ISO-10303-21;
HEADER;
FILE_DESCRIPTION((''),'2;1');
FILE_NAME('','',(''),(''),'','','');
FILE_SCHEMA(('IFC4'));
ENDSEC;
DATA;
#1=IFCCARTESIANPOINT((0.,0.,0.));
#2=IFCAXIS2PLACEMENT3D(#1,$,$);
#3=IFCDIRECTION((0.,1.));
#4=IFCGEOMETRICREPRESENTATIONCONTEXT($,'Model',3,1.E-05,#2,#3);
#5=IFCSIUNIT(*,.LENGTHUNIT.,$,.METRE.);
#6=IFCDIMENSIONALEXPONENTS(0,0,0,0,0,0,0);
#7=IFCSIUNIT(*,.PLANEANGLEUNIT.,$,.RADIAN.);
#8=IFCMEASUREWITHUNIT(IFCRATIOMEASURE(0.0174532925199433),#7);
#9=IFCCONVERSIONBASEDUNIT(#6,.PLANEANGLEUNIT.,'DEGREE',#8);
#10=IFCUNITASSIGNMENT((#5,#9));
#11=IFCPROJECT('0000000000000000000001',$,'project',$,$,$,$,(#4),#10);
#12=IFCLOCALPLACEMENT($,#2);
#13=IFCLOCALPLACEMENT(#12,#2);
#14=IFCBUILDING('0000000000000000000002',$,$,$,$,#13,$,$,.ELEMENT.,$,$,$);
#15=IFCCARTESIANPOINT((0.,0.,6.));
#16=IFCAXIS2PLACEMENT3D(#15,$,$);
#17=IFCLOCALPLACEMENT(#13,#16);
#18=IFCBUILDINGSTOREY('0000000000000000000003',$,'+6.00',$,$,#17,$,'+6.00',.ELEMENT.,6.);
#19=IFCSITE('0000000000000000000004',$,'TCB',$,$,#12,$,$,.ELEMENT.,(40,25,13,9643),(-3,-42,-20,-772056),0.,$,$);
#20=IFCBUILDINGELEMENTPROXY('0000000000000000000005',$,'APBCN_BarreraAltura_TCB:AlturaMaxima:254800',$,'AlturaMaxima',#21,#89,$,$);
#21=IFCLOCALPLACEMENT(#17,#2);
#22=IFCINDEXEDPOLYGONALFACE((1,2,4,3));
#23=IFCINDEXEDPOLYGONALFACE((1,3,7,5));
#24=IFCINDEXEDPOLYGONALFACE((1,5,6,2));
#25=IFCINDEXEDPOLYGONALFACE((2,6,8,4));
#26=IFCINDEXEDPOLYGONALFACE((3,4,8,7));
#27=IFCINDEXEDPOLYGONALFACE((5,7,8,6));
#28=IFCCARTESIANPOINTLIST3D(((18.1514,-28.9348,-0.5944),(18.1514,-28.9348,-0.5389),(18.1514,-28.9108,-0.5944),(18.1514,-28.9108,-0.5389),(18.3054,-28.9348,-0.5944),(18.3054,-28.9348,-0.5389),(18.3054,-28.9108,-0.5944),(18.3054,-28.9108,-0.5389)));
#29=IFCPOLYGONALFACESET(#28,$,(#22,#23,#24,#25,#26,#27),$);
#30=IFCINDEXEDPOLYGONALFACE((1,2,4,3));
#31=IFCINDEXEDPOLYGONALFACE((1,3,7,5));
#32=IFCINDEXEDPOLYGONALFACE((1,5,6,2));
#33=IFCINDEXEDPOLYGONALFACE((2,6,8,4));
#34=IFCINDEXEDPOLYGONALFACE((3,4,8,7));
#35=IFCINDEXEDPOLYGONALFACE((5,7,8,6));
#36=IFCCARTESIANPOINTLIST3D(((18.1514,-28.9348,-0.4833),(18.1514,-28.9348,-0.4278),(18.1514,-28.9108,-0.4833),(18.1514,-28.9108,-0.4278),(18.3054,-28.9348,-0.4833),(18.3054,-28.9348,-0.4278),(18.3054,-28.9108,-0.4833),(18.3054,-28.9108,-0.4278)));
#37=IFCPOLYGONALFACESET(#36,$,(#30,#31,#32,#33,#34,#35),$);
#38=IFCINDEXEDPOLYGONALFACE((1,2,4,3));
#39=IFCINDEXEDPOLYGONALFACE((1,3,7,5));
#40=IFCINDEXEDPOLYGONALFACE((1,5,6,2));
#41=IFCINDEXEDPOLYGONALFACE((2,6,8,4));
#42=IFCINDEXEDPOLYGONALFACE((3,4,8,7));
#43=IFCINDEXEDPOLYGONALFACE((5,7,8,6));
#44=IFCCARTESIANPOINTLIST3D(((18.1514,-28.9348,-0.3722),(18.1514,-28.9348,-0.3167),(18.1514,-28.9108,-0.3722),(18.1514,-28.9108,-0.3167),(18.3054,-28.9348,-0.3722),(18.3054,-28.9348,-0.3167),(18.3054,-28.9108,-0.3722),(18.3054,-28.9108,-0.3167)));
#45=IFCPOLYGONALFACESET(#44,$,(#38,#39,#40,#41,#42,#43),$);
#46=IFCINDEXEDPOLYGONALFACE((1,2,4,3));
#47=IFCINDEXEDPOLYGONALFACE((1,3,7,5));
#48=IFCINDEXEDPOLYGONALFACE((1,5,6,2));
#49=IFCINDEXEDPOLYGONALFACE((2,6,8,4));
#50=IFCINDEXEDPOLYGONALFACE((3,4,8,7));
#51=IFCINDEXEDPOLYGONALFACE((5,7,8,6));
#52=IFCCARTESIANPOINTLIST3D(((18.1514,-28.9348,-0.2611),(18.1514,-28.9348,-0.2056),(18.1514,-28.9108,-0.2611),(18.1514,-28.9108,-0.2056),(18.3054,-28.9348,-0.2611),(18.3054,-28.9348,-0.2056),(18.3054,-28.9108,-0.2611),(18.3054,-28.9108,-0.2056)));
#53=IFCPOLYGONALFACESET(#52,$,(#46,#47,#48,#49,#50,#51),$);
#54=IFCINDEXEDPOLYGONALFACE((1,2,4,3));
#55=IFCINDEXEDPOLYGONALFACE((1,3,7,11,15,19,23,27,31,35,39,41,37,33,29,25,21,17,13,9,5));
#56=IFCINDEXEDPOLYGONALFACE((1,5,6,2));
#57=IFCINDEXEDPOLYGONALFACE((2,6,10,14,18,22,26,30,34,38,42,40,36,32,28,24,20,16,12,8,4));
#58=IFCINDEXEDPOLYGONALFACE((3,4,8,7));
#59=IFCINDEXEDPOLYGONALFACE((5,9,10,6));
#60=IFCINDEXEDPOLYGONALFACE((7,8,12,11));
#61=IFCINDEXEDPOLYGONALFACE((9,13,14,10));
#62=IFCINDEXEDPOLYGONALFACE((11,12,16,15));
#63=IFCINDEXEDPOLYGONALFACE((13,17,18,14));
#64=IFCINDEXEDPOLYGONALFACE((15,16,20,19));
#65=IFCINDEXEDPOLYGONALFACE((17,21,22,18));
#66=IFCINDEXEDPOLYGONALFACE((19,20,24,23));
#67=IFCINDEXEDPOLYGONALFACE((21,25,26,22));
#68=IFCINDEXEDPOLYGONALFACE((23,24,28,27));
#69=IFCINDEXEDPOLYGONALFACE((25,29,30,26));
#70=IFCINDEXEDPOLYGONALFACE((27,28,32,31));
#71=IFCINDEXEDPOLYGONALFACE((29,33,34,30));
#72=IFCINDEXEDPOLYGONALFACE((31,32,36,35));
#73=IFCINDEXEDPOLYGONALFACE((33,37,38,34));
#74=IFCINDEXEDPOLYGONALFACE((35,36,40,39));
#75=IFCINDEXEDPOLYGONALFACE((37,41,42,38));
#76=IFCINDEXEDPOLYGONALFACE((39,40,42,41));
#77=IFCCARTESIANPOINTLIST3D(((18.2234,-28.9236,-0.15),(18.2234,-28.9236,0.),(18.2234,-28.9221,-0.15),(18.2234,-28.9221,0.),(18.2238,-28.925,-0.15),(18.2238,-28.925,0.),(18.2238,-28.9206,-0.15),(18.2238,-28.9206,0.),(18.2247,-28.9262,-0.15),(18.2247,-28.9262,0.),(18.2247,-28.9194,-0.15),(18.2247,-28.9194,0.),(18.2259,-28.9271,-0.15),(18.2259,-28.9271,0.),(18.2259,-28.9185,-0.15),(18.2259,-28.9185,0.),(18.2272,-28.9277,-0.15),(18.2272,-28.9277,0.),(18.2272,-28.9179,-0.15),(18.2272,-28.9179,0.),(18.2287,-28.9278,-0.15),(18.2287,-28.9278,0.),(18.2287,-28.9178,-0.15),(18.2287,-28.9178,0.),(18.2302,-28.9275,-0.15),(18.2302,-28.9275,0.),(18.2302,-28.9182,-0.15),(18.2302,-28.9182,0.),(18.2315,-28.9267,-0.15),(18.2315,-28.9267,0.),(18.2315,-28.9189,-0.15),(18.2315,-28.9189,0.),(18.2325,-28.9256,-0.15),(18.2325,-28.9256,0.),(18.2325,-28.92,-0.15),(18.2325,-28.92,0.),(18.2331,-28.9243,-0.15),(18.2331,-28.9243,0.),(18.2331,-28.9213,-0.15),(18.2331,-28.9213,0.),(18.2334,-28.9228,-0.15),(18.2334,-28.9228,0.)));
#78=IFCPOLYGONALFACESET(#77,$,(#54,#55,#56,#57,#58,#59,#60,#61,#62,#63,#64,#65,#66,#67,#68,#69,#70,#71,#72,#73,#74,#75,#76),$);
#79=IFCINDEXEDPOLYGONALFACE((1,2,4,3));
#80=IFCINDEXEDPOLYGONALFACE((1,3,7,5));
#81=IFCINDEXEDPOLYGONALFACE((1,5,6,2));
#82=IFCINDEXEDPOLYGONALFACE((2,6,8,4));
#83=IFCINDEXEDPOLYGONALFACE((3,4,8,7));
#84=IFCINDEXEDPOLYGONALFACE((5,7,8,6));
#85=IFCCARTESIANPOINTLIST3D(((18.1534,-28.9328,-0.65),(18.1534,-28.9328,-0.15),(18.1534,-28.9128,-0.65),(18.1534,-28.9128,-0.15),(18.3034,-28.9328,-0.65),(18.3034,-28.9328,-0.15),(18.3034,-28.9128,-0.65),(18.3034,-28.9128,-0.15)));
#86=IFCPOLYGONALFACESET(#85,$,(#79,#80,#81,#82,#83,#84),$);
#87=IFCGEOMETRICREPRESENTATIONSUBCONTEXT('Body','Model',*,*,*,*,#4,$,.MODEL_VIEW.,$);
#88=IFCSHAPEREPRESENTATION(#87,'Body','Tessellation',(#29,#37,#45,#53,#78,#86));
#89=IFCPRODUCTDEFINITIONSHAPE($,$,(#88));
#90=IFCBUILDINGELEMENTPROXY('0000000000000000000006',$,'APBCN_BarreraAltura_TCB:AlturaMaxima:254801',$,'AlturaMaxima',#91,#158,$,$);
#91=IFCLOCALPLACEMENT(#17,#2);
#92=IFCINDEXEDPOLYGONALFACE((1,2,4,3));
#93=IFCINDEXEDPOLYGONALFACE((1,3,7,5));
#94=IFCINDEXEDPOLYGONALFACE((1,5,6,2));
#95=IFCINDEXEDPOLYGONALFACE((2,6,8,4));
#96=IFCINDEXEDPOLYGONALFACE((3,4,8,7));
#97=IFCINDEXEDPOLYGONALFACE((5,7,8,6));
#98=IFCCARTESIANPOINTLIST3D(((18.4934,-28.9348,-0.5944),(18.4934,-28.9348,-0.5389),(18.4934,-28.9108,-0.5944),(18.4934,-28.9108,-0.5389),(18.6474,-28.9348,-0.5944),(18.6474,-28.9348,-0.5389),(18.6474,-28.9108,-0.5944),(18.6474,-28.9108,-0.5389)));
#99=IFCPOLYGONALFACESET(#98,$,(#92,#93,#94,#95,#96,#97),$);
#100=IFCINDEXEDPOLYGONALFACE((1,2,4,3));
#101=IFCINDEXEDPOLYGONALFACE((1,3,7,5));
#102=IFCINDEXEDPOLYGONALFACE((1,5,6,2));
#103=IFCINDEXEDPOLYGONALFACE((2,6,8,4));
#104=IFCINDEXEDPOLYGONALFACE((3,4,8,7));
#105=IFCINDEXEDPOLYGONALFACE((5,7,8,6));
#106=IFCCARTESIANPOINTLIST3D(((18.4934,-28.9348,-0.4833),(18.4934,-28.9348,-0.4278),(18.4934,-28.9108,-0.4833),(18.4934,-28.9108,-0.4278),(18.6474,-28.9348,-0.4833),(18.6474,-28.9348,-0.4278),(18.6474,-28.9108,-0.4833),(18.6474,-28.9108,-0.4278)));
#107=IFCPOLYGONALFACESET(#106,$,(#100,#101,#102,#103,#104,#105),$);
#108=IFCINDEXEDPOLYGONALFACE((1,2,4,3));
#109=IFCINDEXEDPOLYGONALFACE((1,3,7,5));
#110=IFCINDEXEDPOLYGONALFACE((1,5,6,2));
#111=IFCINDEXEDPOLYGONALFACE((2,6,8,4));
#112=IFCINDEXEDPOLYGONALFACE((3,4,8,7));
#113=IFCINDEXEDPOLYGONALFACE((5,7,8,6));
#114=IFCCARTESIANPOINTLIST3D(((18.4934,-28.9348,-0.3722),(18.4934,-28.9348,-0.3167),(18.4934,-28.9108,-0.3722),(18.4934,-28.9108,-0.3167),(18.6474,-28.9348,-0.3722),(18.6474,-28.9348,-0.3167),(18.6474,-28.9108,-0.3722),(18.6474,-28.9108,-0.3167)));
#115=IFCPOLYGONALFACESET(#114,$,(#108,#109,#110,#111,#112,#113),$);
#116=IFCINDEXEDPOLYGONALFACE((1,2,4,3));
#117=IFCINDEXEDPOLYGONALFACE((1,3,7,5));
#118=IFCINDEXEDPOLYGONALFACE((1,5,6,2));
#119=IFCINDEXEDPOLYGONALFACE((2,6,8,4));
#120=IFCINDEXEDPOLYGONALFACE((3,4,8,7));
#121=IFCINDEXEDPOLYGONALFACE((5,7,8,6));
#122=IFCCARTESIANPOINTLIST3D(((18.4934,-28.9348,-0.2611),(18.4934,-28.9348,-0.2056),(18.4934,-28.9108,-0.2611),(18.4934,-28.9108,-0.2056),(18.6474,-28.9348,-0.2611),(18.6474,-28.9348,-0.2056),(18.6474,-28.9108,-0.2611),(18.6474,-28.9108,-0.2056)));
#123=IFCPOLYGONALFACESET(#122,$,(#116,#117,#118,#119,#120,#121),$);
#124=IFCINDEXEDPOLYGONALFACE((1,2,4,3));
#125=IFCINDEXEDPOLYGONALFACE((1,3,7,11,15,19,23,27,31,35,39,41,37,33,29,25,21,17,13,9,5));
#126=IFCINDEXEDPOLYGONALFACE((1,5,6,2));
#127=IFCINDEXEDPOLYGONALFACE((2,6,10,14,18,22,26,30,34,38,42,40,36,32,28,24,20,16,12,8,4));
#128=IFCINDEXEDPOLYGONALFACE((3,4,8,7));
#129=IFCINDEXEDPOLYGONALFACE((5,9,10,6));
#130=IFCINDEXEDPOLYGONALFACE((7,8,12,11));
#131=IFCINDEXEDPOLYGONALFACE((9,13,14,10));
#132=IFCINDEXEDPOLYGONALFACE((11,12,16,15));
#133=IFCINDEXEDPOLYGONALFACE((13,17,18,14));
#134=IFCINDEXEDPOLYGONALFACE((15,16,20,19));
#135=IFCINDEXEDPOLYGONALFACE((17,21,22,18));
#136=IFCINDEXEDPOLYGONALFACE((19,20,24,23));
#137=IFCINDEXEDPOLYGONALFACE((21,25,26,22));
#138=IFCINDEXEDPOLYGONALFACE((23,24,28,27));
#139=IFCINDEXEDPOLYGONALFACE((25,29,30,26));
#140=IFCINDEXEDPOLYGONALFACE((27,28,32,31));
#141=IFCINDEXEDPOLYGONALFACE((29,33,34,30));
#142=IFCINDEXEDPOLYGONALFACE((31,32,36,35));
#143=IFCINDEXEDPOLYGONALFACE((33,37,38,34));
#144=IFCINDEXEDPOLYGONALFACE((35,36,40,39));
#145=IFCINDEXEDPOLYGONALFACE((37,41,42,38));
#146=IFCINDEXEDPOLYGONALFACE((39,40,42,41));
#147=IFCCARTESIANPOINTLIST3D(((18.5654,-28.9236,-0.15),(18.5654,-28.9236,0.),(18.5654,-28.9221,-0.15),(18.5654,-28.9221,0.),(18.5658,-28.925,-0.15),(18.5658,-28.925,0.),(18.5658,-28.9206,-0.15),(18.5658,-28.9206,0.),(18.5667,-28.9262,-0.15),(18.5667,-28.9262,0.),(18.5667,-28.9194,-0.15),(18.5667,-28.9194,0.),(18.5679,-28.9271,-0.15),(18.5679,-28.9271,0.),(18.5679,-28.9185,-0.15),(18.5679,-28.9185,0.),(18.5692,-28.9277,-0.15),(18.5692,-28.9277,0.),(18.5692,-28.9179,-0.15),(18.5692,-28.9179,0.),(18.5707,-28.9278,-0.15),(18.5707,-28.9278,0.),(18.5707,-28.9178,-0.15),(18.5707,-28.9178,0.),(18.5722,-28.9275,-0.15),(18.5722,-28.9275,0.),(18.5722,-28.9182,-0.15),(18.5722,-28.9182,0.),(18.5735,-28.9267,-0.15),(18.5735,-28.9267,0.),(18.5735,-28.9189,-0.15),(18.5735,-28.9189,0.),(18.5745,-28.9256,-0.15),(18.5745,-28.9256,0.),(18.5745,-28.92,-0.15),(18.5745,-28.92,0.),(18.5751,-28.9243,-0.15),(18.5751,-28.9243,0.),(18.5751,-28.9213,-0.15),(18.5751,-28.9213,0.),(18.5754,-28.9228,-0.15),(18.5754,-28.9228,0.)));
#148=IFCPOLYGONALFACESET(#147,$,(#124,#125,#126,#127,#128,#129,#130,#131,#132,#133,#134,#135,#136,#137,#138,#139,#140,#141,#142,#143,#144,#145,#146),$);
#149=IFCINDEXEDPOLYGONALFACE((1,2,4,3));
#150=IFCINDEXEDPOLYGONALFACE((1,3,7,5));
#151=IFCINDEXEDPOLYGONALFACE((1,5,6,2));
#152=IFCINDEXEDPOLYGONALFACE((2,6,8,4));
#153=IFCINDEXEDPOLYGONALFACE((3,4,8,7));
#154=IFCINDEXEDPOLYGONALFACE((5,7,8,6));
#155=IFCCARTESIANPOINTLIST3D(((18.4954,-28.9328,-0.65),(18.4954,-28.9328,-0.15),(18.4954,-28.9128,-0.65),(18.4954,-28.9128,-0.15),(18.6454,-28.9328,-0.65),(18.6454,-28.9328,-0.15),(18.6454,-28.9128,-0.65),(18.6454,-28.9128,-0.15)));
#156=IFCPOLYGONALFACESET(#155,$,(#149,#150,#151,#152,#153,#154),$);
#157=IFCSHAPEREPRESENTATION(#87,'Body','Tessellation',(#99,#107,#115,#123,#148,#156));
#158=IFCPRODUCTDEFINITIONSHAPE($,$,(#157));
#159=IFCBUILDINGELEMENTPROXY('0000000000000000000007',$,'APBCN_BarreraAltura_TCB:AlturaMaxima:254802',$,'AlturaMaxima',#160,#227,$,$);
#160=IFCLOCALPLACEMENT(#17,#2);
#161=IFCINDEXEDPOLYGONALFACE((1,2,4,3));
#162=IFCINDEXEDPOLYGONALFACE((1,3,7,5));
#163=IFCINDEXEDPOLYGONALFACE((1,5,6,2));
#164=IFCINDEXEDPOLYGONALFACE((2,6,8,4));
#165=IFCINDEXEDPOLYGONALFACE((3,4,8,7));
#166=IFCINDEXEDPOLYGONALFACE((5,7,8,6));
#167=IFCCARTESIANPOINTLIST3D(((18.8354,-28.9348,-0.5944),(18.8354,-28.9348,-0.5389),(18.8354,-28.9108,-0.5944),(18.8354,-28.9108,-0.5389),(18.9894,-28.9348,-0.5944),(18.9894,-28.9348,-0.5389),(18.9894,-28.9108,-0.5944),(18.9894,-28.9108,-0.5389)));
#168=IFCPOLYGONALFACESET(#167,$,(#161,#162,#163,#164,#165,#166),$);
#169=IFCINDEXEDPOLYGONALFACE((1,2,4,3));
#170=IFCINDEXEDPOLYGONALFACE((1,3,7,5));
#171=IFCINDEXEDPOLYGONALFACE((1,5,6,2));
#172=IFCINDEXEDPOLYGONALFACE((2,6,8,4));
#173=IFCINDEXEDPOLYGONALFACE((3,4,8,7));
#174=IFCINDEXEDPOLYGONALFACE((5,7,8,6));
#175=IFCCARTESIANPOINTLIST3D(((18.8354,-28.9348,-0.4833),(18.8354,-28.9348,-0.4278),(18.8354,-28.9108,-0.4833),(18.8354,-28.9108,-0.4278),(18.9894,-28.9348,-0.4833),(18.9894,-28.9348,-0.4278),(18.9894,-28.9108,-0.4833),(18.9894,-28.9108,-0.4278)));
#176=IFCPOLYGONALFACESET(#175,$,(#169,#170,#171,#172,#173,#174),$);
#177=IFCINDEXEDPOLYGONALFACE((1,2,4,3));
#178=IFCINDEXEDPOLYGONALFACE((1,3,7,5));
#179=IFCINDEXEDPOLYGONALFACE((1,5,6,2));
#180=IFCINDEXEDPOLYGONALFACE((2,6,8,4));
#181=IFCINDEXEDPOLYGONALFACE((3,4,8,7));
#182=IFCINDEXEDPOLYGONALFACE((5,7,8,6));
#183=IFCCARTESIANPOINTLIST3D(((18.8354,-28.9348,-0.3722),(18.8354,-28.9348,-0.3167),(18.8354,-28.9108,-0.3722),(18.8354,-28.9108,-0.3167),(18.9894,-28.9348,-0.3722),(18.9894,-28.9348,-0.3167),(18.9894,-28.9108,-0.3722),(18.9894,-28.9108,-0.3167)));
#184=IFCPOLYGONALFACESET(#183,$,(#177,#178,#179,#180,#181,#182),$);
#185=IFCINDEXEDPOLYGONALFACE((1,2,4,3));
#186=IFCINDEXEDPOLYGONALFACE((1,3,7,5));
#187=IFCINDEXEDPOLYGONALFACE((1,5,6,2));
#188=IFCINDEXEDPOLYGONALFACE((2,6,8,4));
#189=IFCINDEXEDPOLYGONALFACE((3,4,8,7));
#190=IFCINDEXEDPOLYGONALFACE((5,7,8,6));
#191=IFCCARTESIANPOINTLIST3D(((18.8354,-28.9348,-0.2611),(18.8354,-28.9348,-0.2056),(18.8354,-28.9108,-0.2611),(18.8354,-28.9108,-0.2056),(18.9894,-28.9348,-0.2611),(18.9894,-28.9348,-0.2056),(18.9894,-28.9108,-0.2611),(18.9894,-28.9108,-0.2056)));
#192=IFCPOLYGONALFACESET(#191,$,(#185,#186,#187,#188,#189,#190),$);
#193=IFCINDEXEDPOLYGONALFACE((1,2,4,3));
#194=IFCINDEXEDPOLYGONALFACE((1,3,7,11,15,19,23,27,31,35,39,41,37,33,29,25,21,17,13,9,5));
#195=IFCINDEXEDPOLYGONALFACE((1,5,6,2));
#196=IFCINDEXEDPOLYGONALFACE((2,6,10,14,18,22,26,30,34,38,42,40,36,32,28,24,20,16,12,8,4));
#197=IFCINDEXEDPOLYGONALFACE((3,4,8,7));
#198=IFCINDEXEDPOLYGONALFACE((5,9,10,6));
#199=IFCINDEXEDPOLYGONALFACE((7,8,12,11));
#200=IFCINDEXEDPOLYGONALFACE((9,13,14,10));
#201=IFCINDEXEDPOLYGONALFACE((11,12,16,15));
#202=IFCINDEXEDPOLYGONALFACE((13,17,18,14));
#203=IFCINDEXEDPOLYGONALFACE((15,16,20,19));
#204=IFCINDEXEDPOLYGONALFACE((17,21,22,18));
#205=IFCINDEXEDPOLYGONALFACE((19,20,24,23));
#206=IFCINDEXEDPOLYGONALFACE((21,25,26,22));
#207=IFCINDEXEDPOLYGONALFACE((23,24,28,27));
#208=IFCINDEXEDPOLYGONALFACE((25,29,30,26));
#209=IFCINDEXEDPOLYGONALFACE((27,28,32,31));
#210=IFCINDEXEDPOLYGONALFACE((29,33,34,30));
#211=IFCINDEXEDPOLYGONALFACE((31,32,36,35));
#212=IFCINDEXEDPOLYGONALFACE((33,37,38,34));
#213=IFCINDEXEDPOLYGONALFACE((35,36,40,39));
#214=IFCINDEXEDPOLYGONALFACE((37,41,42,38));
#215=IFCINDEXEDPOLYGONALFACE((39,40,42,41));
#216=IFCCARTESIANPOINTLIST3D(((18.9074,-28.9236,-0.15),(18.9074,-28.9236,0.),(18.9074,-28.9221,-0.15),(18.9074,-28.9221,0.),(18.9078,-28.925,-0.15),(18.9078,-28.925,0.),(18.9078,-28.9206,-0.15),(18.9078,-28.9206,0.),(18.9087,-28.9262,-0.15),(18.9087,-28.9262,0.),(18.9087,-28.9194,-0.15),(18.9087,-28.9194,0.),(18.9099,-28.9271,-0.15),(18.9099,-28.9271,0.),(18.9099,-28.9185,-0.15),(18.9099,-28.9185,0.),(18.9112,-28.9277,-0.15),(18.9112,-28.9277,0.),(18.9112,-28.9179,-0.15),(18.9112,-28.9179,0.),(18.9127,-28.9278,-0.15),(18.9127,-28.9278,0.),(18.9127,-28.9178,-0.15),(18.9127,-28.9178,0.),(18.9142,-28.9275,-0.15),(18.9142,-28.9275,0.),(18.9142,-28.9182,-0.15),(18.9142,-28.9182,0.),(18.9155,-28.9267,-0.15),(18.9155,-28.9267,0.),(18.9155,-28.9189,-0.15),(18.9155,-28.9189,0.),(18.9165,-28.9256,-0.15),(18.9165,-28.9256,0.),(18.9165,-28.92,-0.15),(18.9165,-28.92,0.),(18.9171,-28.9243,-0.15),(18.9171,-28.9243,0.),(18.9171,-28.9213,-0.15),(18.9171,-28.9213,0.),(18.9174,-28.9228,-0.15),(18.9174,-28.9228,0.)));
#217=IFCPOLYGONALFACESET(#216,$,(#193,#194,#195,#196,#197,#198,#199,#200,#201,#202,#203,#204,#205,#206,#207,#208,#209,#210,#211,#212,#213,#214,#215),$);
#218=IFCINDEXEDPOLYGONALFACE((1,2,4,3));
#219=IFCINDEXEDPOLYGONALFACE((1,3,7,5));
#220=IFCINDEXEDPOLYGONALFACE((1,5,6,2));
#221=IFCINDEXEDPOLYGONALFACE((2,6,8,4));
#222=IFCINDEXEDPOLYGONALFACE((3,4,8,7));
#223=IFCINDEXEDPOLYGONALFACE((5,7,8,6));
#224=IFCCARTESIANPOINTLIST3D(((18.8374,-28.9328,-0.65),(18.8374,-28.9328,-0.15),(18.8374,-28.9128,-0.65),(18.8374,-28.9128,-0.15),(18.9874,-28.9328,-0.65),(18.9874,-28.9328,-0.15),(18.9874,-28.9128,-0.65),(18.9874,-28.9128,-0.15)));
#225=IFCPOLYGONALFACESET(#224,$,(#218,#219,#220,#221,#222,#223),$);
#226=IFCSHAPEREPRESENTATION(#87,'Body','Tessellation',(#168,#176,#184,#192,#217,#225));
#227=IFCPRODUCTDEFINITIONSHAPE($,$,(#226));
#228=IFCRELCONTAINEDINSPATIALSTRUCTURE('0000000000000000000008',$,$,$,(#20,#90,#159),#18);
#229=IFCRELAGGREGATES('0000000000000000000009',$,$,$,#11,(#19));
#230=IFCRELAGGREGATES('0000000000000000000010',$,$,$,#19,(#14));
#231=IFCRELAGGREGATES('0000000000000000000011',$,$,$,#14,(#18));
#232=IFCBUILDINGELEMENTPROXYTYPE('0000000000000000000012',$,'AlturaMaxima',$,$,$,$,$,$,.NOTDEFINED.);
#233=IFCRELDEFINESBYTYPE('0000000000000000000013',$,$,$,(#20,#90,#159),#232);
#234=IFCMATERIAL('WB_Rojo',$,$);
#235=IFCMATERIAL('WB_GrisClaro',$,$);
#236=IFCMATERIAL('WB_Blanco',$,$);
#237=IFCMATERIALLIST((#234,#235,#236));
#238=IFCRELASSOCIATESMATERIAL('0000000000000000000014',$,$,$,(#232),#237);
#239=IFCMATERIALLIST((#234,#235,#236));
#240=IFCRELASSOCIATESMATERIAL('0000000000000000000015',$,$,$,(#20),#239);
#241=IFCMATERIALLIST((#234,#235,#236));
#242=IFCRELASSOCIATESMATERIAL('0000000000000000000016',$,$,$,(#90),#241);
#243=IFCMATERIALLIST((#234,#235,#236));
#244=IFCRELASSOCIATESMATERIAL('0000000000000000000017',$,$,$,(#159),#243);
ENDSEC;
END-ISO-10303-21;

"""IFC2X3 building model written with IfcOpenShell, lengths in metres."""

from ifc_helpers import new_model, entity, si_unit, converted_unit, direction, frame, frame_2d, origin, origin_2d_with_axis, place, context, subcontext, project, spatial, rectangle, circle, extrude, source, transform, mapped, material, material_list, type_object, type_shapes, element, save


model = new_model("IFC2X3")

# Units and contexts
model_context = context("Model", 3, precision=1e-05, world=origin(), true_north=direction((0.0, 1.0)))
body_context = subcontext(model_context, "Body", "Model", "MODEL_VIEW")
ifc_project = project(units=[si_unit("LENGTHUNIT", "METRE"), converted_unit("PLANEANGLEUNIT", "DEGREE", entity("IfcRatioMeasure", 0.0174532925199433), si_unit("PLANEANGLEUNIT", "RADIAN"), dimensions=[0, 0, 0, 0, 0, 0, 0])], contexts=[model_context])

# Site, building, storey
site_placement = place(None, origin())
site = spatial("IfcSite", under=ifc_project, at=site_placement, Name="TCB", CompositionType="ELEMENT", RefLatitude=(40, 25, 13, 9643), RefLongitude=(-3, -42, -20, -772056), RefElevation=0.0)
building_placement = place(site_placement, origin())
building = spatial("IfcBuilding", under=site, at=building_placement, CompositionType="ELEMENT")
storey_placement = place(building_placement, frame((0.0, 0.0, 6.0)))
storey = spatial("IfcBuildingStorey", under=building, at=storey_placement, Name="+6.00", LongName="+6.00", CompositionType="ELEMENT", Elevation=6.0)

# Building element proxies
ifc_material_1 = material(Name="WB_Rojo")
ifc_material_2 = material(Name="WB_GrisClaro")
ifc_material_3 = material(Name="WB_Blanco")
ifc_material_list_1 = material_list([ifc_material_1, ifc_material_2, ifc_material_3])
building_element_proxy_type = type_object("IfcBuildingElementProxyType", Name="AlturaMaxima", PredefinedType="NOTDEFINED", material=ifc_material_list_1)
shared_shape = source(origin(), body_context, "Body", "SweptSolid", [
    extrude(rectangle(XDim=0.154, YDim=0.024, at=frame_2d((0.0, 0.0), x_axis=(1.0, 0.0))), frame((0.0, 0.0, -0.5944), z_axis=(0.0, 0.0, 1.0), x_axis=(-1.0, 0.0, 0.0)), (0.0, 0.0, 1.0), 0.0556),
    extrude(rectangle(XDim=0.154, YDim=0.024, at=frame_2d((0.0, 0.0), x_axis=(1.0, 0.0))), frame((0.0, 0.0, -0.4833), z_axis=(0.0, 0.0, 1.0), x_axis=(-1.0, 0.0, 0.0)), (0.0, 0.0, 1.0), 0.0556),
    extrude(rectangle(XDim=0.154, YDim=0.024, at=frame_2d((0.0, 0.0), x_axis=(1.0, 0.0))), frame((0.0, 0.0, -0.3722), z_axis=(0.0, 0.0, 1.0), x_axis=(-1.0, 0.0, 0.0)), (0.0, 0.0, 1.0), 0.0556),
    extrude(rectangle(XDim=0.154, YDim=0.024, at=frame_2d((0.0, 0.0), x_axis=(1.0, 0.0))), frame((0.0, 0.0, -0.2611), z_axis=(0.0, 0.0, 1.0), x_axis=(-1.0, 0.0, 0.0)), (0.0, 0.0, 1.0), 0.0556),
    extrude(circle(Radius=0.005, at=frame_2d((0.0, 0.0), x_axis=(1.0, 0.0))), frame((0.0, 0.0, -0.15)), (0.0, 0.0, 1.0), 0.15),
    extrude(rectangle(XDim=0.02, YDim=0.15, at=origin_2d_with_axis()), frame((0.0, 0.0, -0.65), z_axis=(0.0, 0.0, 1.0), x_axis=(0.0, 1.0, 0.0)), (0.0, 0.0, 1.0), 0.5),
])
type_shapes(building_element_proxy_type, [shared_shape])
ifc_material_list_2 = material_list([ifc_material_1, ifc_material_2, ifc_material_3])
proxy_1_placement = place(storey_placement, frame((18.2284, -28.9228, 0.0)))
element("IfcBuildingElementProxy", 1, at=proxy_1_placement, inside=storey, type_object=building_element_proxy_type, material=ifc_material_list_2, Name="APBCN_BarreraAltura_TCB:AlturaMaxima:254800", ObjectType="AlturaMaxima", context=body_context, shape_type="MappedRepresentation", body=[
    mapped(shared_shape, transform((0.0, 0.0, 0.0), scale=1.0)),
])
ifc_material_list_3 = material_list([ifc_material_1, ifc_material_2, ifc_material_3])
proxy_2_placement = place(storey_placement, frame((18.5704, -28.9228, 0.0)))
element("IfcBuildingElementProxy", 2, at=proxy_2_placement, inside=storey, type_object=building_element_proxy_type, material=ifc_material_list_3, Name="APBCN_BarreraAltura_TCB:AlturaMaxima:254801", ObjectType="AlturaMaxima", context=body_context, shape_type="MappedRepresentation", body=[
    mapped(shared_shape, transform((0.0, 0.0, 0.0), scale=1.0)),
])
ifc_material_list_4 = material_list([ifc_material_1, ifc_material_2, ifc_material_3])
proxy_3_placement = place(storey_placement, frame((18.9124, -28.9228, 0.0)))
element("IfcBuildingElementProxy", 3, at=proxy_3_placement, inside=storey, type_object=building_element_proxy_type, material=ifc_material_list_4, Name="APBCN_BarreraAltura_TCB:AlturaMaxima:254802", ObjectType="AlturaMaxima", context=body_context, shape_type="MappedRepresentation", body=[
    mapped(shared_shape, transform((0.0, 0.0, 0.0), scale=1.0)),
])

save(model, "model.ifc")
